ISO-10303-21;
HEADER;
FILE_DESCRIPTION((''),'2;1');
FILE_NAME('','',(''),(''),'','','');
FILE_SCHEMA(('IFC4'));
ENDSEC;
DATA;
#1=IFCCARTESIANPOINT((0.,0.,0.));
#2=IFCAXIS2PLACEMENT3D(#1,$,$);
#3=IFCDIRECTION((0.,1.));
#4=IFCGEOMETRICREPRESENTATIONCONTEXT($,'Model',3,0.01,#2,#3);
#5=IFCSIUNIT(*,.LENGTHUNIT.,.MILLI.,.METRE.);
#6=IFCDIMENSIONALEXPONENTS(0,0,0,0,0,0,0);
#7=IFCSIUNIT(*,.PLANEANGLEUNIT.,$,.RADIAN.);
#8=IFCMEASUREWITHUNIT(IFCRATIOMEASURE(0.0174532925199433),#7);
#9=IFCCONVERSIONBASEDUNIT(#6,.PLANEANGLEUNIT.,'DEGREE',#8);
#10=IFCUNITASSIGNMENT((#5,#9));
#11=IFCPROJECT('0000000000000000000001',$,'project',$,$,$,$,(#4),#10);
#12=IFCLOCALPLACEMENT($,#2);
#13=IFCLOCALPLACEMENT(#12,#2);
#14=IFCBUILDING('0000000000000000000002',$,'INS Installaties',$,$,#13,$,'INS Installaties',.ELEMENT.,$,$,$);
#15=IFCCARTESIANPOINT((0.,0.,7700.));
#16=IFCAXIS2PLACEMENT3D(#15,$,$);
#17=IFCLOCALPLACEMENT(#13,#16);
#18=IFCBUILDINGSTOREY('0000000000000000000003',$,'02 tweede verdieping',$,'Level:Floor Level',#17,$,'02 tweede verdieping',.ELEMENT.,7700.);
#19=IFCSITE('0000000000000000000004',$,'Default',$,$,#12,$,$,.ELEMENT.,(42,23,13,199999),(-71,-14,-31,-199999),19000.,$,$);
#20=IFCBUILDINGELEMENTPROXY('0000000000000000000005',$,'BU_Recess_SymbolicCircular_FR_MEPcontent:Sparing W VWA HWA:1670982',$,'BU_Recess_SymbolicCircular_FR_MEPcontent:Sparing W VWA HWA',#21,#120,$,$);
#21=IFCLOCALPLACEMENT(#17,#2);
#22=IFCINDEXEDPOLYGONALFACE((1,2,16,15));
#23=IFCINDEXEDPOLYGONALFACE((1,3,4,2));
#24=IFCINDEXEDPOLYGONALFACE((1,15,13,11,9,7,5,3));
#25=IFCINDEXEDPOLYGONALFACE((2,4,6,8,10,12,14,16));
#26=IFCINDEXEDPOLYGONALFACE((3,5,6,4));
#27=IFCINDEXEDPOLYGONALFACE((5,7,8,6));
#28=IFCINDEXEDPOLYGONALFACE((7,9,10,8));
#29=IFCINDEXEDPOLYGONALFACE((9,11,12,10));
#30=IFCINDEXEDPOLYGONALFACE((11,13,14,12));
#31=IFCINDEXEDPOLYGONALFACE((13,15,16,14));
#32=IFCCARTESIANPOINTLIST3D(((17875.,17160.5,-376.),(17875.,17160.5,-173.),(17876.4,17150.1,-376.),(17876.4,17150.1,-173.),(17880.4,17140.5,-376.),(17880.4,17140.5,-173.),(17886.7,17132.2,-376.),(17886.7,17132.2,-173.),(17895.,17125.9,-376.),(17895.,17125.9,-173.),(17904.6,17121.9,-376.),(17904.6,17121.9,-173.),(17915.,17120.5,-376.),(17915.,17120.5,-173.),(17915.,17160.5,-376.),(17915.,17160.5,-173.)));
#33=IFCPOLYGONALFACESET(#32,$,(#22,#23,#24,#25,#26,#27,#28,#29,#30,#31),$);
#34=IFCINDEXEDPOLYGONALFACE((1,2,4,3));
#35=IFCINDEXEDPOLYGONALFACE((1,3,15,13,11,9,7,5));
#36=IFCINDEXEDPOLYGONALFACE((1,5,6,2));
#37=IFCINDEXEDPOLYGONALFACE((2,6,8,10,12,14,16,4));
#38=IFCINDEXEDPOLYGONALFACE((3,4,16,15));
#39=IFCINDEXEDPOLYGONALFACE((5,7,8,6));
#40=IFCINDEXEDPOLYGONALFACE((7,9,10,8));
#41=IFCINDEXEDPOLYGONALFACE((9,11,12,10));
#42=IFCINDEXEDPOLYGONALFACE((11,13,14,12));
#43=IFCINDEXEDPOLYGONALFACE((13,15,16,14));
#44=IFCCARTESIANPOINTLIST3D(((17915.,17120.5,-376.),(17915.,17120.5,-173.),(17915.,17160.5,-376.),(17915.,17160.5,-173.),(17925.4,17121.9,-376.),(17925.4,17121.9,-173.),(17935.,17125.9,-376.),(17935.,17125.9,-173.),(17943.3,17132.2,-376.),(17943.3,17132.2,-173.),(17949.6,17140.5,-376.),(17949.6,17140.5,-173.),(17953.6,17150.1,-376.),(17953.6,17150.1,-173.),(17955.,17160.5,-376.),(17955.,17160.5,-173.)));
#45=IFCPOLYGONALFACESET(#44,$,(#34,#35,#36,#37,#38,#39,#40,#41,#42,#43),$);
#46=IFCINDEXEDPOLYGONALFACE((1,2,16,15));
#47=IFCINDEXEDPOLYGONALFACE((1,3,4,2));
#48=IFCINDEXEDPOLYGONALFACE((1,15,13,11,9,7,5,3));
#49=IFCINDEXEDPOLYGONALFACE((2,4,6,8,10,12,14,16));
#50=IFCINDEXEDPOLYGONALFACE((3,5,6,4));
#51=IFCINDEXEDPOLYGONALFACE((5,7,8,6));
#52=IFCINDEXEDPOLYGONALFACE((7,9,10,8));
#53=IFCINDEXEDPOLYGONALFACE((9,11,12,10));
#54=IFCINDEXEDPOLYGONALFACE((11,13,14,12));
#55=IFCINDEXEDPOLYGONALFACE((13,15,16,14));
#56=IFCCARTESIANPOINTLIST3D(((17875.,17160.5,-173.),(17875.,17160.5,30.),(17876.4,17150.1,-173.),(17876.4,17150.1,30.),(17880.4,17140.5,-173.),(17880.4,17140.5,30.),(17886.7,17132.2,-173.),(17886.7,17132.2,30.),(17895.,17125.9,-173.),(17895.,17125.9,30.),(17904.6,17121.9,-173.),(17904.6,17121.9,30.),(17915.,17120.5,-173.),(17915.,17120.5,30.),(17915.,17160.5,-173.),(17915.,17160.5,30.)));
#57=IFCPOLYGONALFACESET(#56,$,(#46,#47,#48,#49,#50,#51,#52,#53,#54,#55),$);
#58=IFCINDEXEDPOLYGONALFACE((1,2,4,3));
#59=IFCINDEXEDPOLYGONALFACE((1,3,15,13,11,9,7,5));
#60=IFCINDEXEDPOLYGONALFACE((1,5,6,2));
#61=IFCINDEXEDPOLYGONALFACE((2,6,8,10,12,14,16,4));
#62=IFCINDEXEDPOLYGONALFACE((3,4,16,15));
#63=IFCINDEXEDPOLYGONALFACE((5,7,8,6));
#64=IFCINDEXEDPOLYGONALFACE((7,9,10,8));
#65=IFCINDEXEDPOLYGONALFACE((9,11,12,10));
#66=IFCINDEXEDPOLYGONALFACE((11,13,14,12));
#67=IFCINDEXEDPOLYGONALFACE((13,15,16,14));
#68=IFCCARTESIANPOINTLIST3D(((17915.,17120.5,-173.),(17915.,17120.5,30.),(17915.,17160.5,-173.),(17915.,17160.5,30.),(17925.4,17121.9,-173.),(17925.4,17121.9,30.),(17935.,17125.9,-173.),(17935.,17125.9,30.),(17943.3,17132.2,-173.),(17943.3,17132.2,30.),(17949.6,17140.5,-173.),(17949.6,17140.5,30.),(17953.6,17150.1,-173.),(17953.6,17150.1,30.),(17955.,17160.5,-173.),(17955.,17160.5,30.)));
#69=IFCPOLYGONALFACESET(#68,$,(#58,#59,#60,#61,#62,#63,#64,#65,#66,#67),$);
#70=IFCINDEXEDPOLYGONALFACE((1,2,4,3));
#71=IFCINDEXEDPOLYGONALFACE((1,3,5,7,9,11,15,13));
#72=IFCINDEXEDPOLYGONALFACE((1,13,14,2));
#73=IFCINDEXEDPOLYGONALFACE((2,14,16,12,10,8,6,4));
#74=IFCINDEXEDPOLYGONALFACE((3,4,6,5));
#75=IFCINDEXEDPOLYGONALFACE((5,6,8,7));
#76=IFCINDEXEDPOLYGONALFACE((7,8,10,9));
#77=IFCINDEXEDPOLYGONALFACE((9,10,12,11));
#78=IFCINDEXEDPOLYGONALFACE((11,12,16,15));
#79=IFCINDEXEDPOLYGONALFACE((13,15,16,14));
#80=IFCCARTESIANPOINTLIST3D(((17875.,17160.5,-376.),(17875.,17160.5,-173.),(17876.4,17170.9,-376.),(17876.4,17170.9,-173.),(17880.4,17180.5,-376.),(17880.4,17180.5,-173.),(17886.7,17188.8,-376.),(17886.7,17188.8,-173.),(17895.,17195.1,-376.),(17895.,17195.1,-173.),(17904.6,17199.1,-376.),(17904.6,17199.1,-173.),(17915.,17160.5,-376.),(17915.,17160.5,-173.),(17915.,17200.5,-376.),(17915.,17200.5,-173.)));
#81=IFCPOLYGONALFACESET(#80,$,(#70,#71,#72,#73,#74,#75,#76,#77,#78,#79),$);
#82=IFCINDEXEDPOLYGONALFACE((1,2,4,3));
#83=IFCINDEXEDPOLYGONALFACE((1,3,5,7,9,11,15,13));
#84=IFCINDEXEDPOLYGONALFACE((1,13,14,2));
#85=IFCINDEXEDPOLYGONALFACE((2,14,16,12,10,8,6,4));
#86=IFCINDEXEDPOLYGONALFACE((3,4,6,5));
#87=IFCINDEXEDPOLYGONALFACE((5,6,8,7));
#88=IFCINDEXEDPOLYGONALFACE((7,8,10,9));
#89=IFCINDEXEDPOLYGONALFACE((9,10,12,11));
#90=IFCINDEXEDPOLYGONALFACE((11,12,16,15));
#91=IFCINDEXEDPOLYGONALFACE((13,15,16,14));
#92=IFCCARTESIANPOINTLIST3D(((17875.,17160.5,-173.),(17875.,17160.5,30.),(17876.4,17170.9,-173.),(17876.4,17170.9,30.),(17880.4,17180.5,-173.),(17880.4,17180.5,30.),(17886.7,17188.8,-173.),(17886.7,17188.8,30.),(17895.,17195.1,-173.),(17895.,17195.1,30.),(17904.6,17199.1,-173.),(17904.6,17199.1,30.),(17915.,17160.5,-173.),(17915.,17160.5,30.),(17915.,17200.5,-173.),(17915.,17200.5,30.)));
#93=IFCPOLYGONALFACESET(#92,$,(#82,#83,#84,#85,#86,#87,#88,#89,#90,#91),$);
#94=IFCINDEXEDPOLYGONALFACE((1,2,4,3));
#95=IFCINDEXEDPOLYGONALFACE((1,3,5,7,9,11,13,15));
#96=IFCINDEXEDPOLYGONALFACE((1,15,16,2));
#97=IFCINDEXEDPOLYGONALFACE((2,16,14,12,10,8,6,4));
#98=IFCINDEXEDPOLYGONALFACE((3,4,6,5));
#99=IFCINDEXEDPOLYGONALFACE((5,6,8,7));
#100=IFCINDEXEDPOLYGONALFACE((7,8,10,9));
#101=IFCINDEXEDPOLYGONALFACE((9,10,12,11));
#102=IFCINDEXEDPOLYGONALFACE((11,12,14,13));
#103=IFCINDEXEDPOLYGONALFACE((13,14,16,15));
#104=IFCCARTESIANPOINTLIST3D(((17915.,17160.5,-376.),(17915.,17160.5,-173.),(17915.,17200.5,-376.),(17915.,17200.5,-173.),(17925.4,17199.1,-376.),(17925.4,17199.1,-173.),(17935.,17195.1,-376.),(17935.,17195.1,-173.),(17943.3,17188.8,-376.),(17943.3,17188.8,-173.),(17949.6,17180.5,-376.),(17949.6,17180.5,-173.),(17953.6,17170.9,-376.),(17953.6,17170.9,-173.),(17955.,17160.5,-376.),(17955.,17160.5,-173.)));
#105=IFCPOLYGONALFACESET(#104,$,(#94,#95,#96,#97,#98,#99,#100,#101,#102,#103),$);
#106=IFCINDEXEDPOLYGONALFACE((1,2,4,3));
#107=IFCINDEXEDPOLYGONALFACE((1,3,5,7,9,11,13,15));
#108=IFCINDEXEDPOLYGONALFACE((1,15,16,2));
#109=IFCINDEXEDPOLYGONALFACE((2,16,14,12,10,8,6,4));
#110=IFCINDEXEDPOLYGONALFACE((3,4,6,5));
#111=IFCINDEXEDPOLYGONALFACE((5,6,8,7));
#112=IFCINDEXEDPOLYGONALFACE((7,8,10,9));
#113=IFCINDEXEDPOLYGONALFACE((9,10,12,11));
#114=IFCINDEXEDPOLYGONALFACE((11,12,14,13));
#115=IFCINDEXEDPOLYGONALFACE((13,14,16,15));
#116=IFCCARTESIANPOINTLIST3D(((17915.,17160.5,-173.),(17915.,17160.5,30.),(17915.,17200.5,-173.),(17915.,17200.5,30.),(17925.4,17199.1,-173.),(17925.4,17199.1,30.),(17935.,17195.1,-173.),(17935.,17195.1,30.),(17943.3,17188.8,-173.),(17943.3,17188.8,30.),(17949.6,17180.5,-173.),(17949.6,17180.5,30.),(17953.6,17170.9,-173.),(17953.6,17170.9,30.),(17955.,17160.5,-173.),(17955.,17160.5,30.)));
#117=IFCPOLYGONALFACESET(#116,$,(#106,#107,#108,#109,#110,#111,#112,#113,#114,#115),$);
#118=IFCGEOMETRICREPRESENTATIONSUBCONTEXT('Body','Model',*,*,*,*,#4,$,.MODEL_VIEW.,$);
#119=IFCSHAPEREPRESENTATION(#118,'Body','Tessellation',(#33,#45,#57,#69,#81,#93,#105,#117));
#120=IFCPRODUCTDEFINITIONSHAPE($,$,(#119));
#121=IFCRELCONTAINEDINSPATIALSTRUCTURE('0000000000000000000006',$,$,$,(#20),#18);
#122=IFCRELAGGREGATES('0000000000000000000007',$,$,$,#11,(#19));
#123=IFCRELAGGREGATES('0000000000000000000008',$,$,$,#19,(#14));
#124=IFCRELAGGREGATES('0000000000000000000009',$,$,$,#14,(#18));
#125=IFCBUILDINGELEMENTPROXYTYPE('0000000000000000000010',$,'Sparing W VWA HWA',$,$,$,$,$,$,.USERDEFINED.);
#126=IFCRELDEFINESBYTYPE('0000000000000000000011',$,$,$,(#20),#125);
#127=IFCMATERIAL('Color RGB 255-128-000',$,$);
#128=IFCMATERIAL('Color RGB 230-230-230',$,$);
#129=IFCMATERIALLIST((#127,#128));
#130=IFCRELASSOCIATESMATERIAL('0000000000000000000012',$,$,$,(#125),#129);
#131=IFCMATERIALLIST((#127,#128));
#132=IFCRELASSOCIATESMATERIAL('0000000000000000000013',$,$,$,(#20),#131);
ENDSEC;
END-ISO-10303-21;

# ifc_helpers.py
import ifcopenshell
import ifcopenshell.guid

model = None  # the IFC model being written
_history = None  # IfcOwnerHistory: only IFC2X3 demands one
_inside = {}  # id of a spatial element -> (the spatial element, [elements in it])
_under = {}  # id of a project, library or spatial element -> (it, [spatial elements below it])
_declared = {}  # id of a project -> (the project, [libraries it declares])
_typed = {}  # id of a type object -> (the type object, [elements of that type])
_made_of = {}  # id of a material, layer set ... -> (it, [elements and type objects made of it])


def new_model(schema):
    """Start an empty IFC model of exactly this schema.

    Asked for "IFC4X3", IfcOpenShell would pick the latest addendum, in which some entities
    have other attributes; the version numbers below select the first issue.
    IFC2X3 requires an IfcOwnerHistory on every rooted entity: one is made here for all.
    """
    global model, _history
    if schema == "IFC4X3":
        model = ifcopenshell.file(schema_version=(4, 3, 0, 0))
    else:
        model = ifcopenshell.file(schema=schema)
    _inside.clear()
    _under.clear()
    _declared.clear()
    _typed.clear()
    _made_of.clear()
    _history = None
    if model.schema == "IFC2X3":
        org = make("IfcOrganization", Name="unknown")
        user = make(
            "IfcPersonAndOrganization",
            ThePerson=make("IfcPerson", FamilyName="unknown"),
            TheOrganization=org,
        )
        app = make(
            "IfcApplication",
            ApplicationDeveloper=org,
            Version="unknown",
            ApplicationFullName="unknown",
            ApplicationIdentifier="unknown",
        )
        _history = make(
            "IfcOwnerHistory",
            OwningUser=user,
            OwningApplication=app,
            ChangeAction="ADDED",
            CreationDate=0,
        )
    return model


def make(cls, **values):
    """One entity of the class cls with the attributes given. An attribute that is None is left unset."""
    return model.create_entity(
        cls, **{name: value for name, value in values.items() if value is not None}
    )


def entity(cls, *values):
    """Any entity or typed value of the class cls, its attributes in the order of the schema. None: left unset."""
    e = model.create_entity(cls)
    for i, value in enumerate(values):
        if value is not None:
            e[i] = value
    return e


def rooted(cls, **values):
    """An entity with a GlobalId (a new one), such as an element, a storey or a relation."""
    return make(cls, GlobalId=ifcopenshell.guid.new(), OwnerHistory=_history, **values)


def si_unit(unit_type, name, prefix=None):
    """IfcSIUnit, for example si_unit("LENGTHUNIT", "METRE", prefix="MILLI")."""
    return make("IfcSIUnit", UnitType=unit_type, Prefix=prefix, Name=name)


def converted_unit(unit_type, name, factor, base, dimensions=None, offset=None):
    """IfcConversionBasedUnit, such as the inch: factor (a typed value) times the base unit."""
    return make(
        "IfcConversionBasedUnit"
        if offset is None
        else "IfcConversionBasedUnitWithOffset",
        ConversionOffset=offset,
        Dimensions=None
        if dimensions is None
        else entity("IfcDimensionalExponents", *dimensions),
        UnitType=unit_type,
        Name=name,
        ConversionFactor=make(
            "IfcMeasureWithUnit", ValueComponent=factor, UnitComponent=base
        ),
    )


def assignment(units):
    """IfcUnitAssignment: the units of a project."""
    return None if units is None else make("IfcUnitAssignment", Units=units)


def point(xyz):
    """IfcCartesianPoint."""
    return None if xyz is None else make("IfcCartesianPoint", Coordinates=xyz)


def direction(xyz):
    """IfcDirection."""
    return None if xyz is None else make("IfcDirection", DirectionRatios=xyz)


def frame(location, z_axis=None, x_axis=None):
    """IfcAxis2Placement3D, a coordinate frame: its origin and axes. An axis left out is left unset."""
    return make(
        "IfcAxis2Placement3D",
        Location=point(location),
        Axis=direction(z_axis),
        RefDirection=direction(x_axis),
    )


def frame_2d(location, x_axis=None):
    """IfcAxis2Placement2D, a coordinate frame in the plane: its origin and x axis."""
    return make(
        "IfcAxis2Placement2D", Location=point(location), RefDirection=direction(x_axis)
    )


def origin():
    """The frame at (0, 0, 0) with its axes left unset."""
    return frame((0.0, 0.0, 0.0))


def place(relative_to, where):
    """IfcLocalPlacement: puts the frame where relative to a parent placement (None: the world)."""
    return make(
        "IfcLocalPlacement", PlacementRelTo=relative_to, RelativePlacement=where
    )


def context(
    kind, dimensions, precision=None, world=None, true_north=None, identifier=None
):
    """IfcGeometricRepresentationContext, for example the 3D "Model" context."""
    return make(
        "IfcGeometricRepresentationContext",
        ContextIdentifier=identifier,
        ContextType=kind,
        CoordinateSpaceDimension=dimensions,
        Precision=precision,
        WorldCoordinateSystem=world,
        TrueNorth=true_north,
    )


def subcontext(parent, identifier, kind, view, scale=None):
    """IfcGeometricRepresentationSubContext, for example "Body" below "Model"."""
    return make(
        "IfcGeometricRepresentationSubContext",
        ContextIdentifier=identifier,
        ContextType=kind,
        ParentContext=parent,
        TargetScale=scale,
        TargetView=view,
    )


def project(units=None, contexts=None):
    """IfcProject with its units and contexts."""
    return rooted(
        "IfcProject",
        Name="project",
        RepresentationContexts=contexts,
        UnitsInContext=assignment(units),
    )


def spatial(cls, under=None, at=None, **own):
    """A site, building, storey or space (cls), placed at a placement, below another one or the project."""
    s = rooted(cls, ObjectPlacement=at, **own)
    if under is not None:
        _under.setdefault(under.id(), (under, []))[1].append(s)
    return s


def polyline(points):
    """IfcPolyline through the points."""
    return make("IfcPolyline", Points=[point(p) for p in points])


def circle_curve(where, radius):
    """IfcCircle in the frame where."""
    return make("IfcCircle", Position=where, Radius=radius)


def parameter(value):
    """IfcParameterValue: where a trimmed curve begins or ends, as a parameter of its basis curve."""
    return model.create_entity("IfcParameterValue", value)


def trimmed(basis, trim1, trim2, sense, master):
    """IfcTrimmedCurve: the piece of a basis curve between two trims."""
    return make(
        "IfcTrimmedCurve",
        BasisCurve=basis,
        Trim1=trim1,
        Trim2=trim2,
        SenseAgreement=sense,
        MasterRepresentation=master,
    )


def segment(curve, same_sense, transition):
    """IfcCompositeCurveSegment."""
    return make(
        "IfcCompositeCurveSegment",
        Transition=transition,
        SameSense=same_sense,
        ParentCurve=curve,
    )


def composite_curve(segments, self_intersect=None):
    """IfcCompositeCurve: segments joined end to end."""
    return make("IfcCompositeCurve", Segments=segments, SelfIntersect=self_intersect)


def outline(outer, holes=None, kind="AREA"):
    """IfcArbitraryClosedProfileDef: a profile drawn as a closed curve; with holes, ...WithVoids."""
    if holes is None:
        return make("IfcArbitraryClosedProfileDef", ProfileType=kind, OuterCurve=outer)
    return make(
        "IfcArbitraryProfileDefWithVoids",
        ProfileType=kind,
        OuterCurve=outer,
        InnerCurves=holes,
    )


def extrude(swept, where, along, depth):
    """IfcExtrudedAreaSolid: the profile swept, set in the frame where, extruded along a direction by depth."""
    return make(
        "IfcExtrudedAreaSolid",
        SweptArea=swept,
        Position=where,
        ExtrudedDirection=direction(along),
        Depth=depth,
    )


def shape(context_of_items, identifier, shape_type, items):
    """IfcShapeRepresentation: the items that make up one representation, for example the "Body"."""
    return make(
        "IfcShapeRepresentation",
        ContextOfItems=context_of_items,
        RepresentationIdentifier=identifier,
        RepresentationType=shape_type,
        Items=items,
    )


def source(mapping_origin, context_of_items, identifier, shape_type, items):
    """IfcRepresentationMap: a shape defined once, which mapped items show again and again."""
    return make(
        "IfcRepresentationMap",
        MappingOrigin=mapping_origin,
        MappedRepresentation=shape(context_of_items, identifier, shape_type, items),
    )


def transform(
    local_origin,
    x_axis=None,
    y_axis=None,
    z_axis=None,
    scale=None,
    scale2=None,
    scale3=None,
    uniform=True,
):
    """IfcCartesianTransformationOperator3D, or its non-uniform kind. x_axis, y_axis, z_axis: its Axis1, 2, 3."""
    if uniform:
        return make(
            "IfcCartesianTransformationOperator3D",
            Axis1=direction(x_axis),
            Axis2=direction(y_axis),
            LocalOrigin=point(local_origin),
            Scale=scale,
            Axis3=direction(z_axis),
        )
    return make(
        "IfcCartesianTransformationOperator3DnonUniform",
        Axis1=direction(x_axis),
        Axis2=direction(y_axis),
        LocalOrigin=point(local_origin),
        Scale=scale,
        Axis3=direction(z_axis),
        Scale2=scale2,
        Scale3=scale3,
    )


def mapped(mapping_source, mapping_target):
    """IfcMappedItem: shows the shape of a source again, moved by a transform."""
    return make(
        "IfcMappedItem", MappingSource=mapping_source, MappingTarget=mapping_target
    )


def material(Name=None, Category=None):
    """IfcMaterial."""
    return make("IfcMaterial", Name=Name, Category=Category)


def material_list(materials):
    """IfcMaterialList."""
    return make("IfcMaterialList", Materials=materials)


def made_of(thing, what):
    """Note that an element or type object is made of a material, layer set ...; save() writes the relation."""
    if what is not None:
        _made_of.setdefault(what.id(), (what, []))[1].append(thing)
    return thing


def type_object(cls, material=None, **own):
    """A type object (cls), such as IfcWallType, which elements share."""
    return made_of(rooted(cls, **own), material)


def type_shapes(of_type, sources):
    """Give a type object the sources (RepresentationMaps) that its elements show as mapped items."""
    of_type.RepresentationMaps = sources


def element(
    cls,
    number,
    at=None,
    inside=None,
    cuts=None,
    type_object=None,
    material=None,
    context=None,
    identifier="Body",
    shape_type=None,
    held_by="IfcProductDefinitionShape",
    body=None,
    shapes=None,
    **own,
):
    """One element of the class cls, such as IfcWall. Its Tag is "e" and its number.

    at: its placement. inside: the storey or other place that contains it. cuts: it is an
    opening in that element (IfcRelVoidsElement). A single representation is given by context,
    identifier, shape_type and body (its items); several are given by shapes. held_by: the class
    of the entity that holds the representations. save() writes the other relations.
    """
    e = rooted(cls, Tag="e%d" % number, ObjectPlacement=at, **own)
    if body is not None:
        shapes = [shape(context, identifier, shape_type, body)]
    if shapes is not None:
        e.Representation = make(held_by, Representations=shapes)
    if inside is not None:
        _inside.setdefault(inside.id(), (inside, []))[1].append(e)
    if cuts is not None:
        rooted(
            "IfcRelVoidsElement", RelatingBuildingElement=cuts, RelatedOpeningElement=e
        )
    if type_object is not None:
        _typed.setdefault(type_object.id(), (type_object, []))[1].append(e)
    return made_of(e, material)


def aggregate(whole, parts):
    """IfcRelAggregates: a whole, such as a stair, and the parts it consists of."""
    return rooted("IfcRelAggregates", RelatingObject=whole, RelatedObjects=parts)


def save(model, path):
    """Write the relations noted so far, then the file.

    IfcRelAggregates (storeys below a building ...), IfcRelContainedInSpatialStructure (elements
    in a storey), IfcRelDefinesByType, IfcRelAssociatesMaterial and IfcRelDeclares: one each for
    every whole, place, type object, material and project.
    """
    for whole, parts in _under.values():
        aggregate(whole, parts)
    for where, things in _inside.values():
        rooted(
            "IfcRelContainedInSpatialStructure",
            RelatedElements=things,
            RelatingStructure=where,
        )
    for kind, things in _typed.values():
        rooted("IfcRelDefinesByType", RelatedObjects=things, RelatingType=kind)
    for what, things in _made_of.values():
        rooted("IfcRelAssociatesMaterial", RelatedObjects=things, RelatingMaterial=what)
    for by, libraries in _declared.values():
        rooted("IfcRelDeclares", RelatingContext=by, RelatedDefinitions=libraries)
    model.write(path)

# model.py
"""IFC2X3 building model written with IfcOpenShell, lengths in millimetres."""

from ifc_helpers import new_model, entity, si_unit, converted_unit, direction, frame, frame_2d, origin, place, context, subcontext, project, spatial, polyline, circle_curve, parameter, trimmed, segment, composite_curve, outline, extrude, source, transform, mapped, material, material_list, type_object, type_shapes, element, save


model = new_model("IFC2X3")

# Units and contexts
model_context = context("Model", 3, precision=0.01, world=origin(), true_north=direction((0.0, 1.0)))
body_context = subcontext(model_context, "Body", "Model", "MODEL_VIEW")
ifc_project = project(units=[si_unit("LENGTHUNIT", "METRE", prefix="MILLI"), converted_unit("PLANEANGLEUNIT", "DEGREE", entity("IfcRatioMeasure", 0.0174532925199433), si_unit("PLANEANGLEUNIT", "RADIAN"), dimensions=[0, 0, 0, 0, 0, 0, 0])], contexts=[model_context])

# Site, building, storey
site_placement = place(None, origin())
site = spatial("IfcSite", under=ifc_project, at=site_placement, Name="Default", CompositionType="ELEMENT", RefLatitude=(42, 23, 13, 199999), RefLongitude=(-71, -14, -31, -199999), RefElevation=19000.0)
building_placement = place(site_placement, origin())
building = spatial("IfcBuilding", under=site, at=building_placement, Name="INS Installaties", LongName="INS Installaties", CompositionType="ELEMENT")
storey_placement = place(building_placement, frame((0.0, 0.0, 7700.0)))
storey = spatial("IfcBuildingStorey", under=building, at=storey_placement, Name="02 tweede verdieping", ObjectType="Level:Floor Level", LongName="02 tweede verdieping", CompositionType="ELEMENT", Elevation=7700.0)

# Building element proxy
ifc_material_1 = material(Name="Color RGB 255-128-000")
ifc_material_2 = material(Name="Color RGB 230-230-230")
ifc_material_list_1 = material_list([ifc_material_1, ifc_material_2])
building_element_proxy_type_1 = type_object("IfcBuildingElementProxyType", Name="Sparing W VWA HWA", PredefinedType="USERDEFINED", material=ifc_material_list_1)
shared_shape_1 = source(origin(), body_context, "Body", "SweptSolid", [
    extrude(outline(composite_curve([segment(trimmed(circle_curve(frame_2d((13.3, 13.3), x_axis=(1.0, 0.0)), 40.0), [parameter(180.0)], [parameter(270.0)], True, "PARAMETER"), True, "CONTINUOUS"), segment(polyline([(13.3, -26.7), (13.3, 13.3)]), True, "CONTINUOUS"), segment(polyline([(13.3, 13.3), (-26.7, 13.3)]), True, "CONTINUOUS")], self_intersect=False)), frame((13.3, 13.3, -403.0), z_axis=(0.0, 0.0, 1.0), x_axis=(-1.0, 0.0, 0.0)), (0.0, 0.0, 1.0), 203.0),
    extrude(outline(composite_curve([segment(polyline([(-26.7, -13.3), (13.3, -13.3)]), True, "CONTINUOUS"), segment(polyline([(13.3, -13.3), (13.3, 26.7)]), True, "CONTINUOUS"), segment(trimmed(circle_curve(frame_2d((13.3, -13.3), x_axis=(1.0, 0.0)), 40.0), [parameter(90.0)], [parameter(180.0)], True, "PARAMETER"), True, "CONTINUOUS")], self_intersect=False)), frame((-13.3, 13.3, -403.0)), (0.0, 0.0, 1.0), 203.0),
    extrude(outline(composite_curve([segment(trimmed(circle_curve(frame_2d((13.3, 13.3), x_axis=(1.0, 0.0)), 40.0), [parameter(180.0)], [parameter(270.0)], True, "PARAMETER"), True, "CONTINUOUS"), segment(polyline([(13.3, -26.7), (13.3, 13.3)]), True, "CONTINUOUS"), segment(polyline([(13.3, 13.3), (-26.7, 13.3)]), True, "CONTINUOUS")], self_intersect=False)), frame((13.3, 13.3, -200.0), z_axis=(0.0, 0.0, 1.0), x_axis=(-1.0, 0.0, 0.0)), (0.0, 0.0, 1.0), 203.0),
    extrude(outline(composite_curve([segment(polyline([(-26.7, -13.3), (13.3, -13.3)]), True, "CONTINUOUS"), segment(polyline([(13.3, -13.3), (13.3, 26.7)]), True, "CONTINUOUS"), segment(trimmed(circle_curve(frame_2d((13.3, -13.3), x_axis=(1.0, 0.0)), 40.0), [parameter(90.0)], [parameter(180.0)], True, "PARAMETER"), True, "CONTINUOUS")], self_intersect=False)), frame((-13.3, 13.3, -200.0)), (0.0, 0.0, 1.0), 203.0),
    extrude(outline(composite_curve([segment(polyline([(-26.7, -13.3), (13.3, -13.3)]), True, "CONTINUOUS"), segment(polyline([(13.3, -13.3), (13.3, 26.7)]), True, "CONTINUOUS"), segment(trimmed(circle_curve(frame_2d((13.3, -13.3), x_axis=(1.0, 0.0)), 40.0), [parameter(90.0)], [parameter(180.0)], True, "PARAMETER"), True, "CONTINUOUS")], self_intersect=False)), frame((13.3, -13.3, -403.0), z_axis=(0.0, 0.0, 1.0), x_axis=(-1.0, 0.0, 0.0)), (0.0, 0.0, 1.0), 203.0),
    extrude(outline(composite_curve([segment(polyline([(-26.7, -13.3), (13.3, -13.3)]), True, "CONTINUOUS"), segment(polyline([(13.3, -13.3), (13.3, 26.7)]), True, "CONTINUOUS"), segment(trimmed(circle_curve(frame_2d((13.3, -13.3), x_axis=(1.0, 0.0)), 40.0), [parameter(90.0)], [parameter(180.0)], True, "PARAMETER"), True, "CONTINUOUS")], self_intersect=False)), frame((13.3, -13.3, -200.0), z_axis=(0.0, 0.0, 1.0), x_axis=(-1.0, 0.0, 0.0)), (0.0, 0.0, 1.0), 203.0),
    extrude(outline(composite_curve([segment(trimmed(circle_curve(frame_2d((13.3, 13.3), x_axis=(1.0, 0.0)), 40.0), [parameter(180.0)], [parameter(270.0)], True, "PARAMETER"), True, "CONTINUOUS"), segment(polyline([(13.3, -26.7), (13.3, 13.3)]), True, "CONTINUOUS"), segment(polyline([(13.3, 13.3), (-26.7, 13.3)]), True, "CONTINUOUS")], self_intersect=False)), frame((-13.3, -13.3, -403.0)), (0.0, 0.0, 1.0), 203.0),
    extrude(outline(composite_curve([segment(trimmed(circle_curve(frame_2d((13.3, 13.3), x_axis=(1.0, 0.0)), 40.0), [parameter(180.0)], [parameter(270.0)], True, "PARAMETER"), True, "CONTINUOUS"), segment(polyline([(13.3, -26.7), (13.3, 13.3)]), True, "CONTINUOUS"), segment(polyline([(13.3, 13.3), (-26.7, 13.3)]), True, "CONTINUOUS")], self_intersect=False)), frame((-13.3, -13.3, -200.0)), (0.0, 0.0, 1.0), 203.0),
])
type_shapes(building_element_proxy_type_1, [shared_shape_1])
ifc_material_list_2 = material_list([ifc_material_1, ifc_material_2])
proxy_1_placement = place(storey_placement, frame((17915.0, 17160.5, 27.0), z_axis=(0.0, 0.0, 1.0), x_axis=(-1.0, 0.0, 0.0)))
element("IfcBuildingElementProxy", 1, at=proxy_1_placement, inside=storey, type_object=building_element_proxy_type_1, material=ifc_material_list_2, Name="BU_Recess_SymbolicCircular_FR_MEPcontent:Sparing W VWA HWA:1670982", ObjectType="BU_Recess_SymbolicCircular_FR_MEPcontent:Sparing W VWA HWA", context=body_context, shape_type="MappedRepresentation", body=[
    mapped(shared_shape_1, transform((0.0, 0.0, 0.0), scale=1.0)),
])

save(model, "model.ifc")
